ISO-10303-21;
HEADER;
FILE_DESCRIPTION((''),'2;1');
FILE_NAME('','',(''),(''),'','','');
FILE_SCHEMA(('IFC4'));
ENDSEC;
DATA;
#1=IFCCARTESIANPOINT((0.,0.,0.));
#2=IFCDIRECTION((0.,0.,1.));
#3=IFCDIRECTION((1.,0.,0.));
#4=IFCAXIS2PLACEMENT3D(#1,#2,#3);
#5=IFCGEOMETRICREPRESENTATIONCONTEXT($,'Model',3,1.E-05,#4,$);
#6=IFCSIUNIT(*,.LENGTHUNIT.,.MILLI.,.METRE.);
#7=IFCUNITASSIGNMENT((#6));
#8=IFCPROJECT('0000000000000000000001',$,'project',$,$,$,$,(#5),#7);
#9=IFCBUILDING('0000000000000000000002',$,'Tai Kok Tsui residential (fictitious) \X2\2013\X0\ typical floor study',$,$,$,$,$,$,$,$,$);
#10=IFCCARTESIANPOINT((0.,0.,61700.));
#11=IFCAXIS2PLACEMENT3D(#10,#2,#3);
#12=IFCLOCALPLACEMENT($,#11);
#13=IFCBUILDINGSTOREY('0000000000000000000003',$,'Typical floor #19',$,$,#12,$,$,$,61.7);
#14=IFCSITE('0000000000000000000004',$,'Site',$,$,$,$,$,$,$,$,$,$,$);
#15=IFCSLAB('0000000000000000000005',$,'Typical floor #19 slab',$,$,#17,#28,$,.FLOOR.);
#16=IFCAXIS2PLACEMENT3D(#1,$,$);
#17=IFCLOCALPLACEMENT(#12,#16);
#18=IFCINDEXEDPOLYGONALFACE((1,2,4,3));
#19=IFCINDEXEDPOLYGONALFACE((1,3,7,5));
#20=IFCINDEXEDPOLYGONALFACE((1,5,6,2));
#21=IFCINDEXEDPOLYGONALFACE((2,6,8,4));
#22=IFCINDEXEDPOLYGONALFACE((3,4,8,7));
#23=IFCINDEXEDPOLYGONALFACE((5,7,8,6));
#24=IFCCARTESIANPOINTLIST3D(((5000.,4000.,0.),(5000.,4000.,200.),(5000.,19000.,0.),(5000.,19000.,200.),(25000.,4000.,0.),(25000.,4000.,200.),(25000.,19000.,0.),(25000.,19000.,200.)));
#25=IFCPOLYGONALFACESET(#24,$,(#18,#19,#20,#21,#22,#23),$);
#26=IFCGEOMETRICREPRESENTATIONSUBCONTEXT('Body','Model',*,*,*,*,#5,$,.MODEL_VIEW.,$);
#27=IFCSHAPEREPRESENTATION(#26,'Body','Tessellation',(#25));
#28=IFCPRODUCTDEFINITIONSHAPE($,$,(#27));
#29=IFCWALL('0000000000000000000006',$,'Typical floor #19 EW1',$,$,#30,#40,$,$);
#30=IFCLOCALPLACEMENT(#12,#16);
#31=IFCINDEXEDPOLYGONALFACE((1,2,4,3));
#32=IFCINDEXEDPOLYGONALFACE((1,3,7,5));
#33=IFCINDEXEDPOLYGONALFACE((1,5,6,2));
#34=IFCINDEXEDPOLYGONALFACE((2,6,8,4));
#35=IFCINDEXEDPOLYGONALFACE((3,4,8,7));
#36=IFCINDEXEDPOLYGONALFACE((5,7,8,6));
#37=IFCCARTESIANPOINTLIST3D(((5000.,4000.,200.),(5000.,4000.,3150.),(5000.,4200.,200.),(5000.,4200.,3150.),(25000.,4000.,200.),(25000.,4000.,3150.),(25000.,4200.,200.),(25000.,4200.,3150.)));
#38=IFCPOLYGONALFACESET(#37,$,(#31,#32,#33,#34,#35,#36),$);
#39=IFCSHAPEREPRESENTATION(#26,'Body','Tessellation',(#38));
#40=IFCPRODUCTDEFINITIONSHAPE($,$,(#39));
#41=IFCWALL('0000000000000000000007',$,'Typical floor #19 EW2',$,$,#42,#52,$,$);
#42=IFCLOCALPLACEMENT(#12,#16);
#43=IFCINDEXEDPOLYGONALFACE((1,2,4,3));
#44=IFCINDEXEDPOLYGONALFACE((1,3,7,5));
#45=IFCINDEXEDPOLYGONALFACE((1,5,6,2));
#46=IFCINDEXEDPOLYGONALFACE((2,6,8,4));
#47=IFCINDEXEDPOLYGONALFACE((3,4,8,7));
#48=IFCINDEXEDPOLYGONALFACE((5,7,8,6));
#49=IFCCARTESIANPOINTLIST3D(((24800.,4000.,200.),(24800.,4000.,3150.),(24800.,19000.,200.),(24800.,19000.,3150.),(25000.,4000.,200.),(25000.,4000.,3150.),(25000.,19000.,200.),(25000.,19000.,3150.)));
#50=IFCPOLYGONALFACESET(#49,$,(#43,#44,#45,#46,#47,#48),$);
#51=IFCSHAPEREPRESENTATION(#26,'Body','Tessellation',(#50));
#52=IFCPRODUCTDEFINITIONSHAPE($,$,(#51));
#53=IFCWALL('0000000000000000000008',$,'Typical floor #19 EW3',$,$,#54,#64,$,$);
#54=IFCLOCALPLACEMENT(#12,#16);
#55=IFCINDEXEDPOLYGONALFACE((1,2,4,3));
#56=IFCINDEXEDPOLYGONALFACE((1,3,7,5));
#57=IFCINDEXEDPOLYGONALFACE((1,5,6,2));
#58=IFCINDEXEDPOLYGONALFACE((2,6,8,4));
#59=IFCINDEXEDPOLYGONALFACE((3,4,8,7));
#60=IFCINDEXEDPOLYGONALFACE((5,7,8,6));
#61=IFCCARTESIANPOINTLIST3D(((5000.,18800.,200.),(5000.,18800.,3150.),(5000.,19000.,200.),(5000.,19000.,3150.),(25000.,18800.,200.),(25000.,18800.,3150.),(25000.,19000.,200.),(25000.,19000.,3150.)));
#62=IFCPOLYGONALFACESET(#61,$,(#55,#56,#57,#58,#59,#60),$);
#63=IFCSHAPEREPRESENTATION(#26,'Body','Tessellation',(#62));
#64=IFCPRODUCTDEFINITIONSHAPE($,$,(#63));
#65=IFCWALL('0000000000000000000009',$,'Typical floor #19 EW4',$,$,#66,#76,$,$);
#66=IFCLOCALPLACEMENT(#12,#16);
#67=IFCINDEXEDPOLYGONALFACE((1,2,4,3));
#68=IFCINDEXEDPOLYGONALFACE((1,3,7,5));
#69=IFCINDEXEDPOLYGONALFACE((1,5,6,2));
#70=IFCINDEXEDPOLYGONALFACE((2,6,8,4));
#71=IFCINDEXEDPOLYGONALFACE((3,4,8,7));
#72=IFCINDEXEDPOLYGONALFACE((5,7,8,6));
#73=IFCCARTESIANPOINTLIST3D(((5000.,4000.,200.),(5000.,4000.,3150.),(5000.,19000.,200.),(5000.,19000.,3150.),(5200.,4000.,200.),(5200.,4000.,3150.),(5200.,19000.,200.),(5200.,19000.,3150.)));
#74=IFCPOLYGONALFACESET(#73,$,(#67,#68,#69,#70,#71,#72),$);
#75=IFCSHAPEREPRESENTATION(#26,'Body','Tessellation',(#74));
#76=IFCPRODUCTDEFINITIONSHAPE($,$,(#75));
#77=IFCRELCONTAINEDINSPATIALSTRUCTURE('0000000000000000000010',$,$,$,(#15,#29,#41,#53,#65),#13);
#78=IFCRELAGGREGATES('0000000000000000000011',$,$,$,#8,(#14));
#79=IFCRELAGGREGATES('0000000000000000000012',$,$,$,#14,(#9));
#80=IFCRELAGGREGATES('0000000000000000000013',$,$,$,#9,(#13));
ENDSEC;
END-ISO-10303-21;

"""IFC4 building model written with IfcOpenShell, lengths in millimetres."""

from ifc_helpers import new_model, si_unit, frame, origin_with_axes, place, context, subcontext, project, spatial, indexed_curve, outline, extrude, element, save


model = new_model("IFC4")

# Units and contexts
model_context = context("Model", 3, precision=1e-05, world=origin_with_axes())
body_context = subcontext(model_context, "Body", "Model", "MODEL_VIEW")
ifc_project = project(units=[si_unit("LENGTHUNIT", "METRE", prefix="MILLI")], contexts=[model_context])

# Site, building, storey
site = spatial("IfcSite", under=ifc_project, Name="Site")
building = spatial("IfcBuilding", under=site, Name="Tai Kok Tsui residential (fictitious) – typical floor study")
storey_placement = place(None, frame((0.0, 0.0, 61700.0), z_axis=(0.0, 0.0, 1.0), x_axis=(1.0, 0.0, 0.0)))
storey = spatial("IfcBuildingStorey", under=building, at=storey_placement, Name="Typical floor #19", Elevation=61.7)

# Slab
slab_placement = place(storey_placement, origin_with_axes())
element("IfcSlab", 1, at=slab_placement, inside=storey, Name="Typical floor #19 slab", PredefinedType="FLOOR", context=body_context, shape_type="SweptSolid", body=[
    extrude(outline(indexed_curve([(5000.0, 4000.0), (25000.0, 4000.0), (25000.0, 19000.0), (5000.0, 19000.0)])), None, (0.0, 0.0, 1.0), 200.0),
])

# Walls
wall_1_placement = place(storey_placement, frame((5000.0, 4000.0, 200.0), z_axis=(0.0, 0.0, 1.0), x_axis=(1.0, 0.0, 0.0)))
element("IfcWall", 2, at=wall_1_placement, inside=storey, Name="Typical floor #19 EW1", context=body_context, shape_type="SweptSolid", body=[
    extrude(outline(indexed_curve([(0.0, 0.0), (0.0, 200.0), (20000.0, 200.0), (20000.0, 0.0), (0.0, 0.0)], self_intersect=False)), origin_with_axes(), (0.0, 0.0, 1.0), 2950.0),
])
wall_2_placement = place(storey_placement, frame((25000.0, 4000.0, 200.0), z_axis=(0.0, 0.0, 1.0), x_axis=(0.0, 1.0, 0.0)))
element("IfcWall", 3, at=wall_2_placement, inside=storey, Name="Typical floor #19 EW2", context=body_context, shape_type="SweptSolid", body=[
    extrude(outline(indexed_curve([(0.0, 0.0), (0.0, 200.0), (15000.0, 200.0), (15000.0, 0.0), (0.0, 0.0)], self_intersect=False)), origin_with_axes(), (0.0, 0.0, 1.0), 2950.0),
])
wall_3_placement = place(storey_placement, frame((25000.0, 19000.0, 200.0), z_axis=(0.0, 0.0, 1.0), x_axis=(-1.0, 0.0, 0.0)))
element("IfcWall", 4, at=wall_3_placement, inside=storey, Name="Typical floor #19 EW3", context=body_context, shape_type="SweptSolid", body=[
    extrude(outline(indexed_curve([(0.0, 0.0), (0.0, 200.0), (20000.0, 200.0), (20000.0, 0.0), (0.0, 0.0)], self_intersect=False)), origin_with_axes(), (0.0, 0.0, 1.0), 2950.0),
])
wall_4_placement = place(storey_placement, frame((5000.0, 19000.0, 200.0), z_axis=(0.0, 0.0, 1.0), x_axis=(0.0, -1.0, 0.0)))
element("IfcWall", 5, at=wall_4_placement, inside=storey, Name="Typical floor #19 EW4", context=body_context, shape_type="SweptSolid", body=[
    extrude(outline(indexed_curve([(0.0, 0.0), (0.0, 200.0), (15000.0, 200.0), (15000.0, 0.0), (0.0, 0.0)], self_intersect=False)), origin_with_axes(), (0.0, 0.0, 1.0), 2950.0),
])

save(model, "model.ifc")
